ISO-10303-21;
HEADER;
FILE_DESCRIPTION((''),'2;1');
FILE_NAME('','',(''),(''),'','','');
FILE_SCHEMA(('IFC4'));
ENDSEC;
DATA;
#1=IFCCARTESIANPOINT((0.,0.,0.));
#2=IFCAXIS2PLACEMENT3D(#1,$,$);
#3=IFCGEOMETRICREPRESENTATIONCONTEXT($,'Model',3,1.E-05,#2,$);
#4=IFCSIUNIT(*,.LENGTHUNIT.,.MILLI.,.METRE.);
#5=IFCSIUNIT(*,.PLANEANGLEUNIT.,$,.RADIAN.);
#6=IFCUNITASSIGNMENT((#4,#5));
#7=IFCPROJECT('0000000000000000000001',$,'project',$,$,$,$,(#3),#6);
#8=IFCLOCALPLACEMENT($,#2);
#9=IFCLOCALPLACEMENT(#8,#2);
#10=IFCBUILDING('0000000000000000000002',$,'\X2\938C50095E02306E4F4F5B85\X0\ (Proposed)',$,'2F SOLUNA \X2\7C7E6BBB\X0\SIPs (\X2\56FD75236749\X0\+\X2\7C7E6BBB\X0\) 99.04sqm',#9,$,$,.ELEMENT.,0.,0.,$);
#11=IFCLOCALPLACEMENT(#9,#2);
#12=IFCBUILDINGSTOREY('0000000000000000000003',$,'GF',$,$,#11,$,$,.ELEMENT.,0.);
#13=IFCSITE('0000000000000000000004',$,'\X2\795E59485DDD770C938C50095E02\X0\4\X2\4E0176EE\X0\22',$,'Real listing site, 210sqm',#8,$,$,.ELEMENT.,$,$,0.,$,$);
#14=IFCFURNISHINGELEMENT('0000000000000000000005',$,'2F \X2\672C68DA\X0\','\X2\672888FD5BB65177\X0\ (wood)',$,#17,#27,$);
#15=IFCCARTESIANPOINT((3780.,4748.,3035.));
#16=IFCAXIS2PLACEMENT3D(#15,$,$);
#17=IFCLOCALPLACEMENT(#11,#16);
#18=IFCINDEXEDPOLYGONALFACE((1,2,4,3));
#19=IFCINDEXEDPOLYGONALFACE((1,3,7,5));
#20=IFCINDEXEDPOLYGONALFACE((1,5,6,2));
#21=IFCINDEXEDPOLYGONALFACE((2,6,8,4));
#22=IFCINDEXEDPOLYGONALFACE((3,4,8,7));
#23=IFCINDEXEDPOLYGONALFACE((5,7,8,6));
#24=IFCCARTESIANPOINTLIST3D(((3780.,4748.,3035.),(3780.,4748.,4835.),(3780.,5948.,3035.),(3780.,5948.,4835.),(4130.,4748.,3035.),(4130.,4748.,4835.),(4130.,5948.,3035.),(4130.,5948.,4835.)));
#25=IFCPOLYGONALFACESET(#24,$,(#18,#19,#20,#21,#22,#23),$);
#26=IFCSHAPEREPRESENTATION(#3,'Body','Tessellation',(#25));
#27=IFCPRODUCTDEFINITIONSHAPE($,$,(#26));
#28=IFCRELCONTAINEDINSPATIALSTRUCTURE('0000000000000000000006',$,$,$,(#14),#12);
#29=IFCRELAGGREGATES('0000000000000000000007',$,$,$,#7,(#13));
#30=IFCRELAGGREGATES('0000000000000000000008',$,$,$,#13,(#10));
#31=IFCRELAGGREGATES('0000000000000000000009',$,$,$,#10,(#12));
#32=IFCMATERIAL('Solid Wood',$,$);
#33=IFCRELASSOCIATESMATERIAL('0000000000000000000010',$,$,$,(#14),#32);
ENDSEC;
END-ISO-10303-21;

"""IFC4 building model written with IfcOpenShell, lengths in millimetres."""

from ifc_helpers import new_model, si_unit, frame, frame_2d, origin, place, context, project, spatial, rectangle, extrude, material, element, save


model = new_model("IFC4")

# Units and contexts
model_context = context("Model", 3, precision=1e-05, world=origin())
ifc_project = project(units=[si_unit("LENGTHUNIT", "METRE", prefix="MILLI"), si_unit("PLANEANGLEUNIT", "RADIAN")], contexts=[model_context])

# Site, building, storey
site_placement = place(None, origin())
site = spatial("IfcSite", under=ifc_project, at=site_placement, Name="神奈川県鎌倉市4丁目22", ObjectType="Real listing site, 210sqm", CompositionType="ELEMENT", RefElevation=0.0)
building_placement = place(site_placement, origin())
building = spatial("IfcBuilding", under=site, at=building_placement, Name="鎌倉市の住宅 (Proposed)", ObjectType="2F SOLUNA 籾殻SIPs (国産杉+籾殻) 99.04sqm", CompositionType="ELEMENT", ElevationOfRefHeight=0.0, ElevationOfTerrain=0.0)
storey_placement = place(building_placement, origin())
storey = spatial("IfcBuildingStorey", under=building, at=storey_placement, Name="GF", CompositionType="ELEMENT", Elevation=0.0)

# Shared definitions
ifc_material_1 = material(Name="Solid Wood")

# Furnishing element
furnishing_placement = place(storey_placement, frame((3780.0, 4748.0, 3035.0)))
element("IfcFurnishingElement", 1, at=furnishing_placement, inside=storey, material=ifc_material_1, Name="2F 本棚", Description="木製家具 (wood)", context=model_context, shape_type="SweptSolid", body=[
    extrude(rectangle(XDim=350.0, YDim=1200.0, at=frame_2d((175.0, 600.0))), frame((3780.0, 4748.0, 3035.0)), (0.0, 0.0, 1.0), 1800.0),
])

save(model, "model.ifc")
